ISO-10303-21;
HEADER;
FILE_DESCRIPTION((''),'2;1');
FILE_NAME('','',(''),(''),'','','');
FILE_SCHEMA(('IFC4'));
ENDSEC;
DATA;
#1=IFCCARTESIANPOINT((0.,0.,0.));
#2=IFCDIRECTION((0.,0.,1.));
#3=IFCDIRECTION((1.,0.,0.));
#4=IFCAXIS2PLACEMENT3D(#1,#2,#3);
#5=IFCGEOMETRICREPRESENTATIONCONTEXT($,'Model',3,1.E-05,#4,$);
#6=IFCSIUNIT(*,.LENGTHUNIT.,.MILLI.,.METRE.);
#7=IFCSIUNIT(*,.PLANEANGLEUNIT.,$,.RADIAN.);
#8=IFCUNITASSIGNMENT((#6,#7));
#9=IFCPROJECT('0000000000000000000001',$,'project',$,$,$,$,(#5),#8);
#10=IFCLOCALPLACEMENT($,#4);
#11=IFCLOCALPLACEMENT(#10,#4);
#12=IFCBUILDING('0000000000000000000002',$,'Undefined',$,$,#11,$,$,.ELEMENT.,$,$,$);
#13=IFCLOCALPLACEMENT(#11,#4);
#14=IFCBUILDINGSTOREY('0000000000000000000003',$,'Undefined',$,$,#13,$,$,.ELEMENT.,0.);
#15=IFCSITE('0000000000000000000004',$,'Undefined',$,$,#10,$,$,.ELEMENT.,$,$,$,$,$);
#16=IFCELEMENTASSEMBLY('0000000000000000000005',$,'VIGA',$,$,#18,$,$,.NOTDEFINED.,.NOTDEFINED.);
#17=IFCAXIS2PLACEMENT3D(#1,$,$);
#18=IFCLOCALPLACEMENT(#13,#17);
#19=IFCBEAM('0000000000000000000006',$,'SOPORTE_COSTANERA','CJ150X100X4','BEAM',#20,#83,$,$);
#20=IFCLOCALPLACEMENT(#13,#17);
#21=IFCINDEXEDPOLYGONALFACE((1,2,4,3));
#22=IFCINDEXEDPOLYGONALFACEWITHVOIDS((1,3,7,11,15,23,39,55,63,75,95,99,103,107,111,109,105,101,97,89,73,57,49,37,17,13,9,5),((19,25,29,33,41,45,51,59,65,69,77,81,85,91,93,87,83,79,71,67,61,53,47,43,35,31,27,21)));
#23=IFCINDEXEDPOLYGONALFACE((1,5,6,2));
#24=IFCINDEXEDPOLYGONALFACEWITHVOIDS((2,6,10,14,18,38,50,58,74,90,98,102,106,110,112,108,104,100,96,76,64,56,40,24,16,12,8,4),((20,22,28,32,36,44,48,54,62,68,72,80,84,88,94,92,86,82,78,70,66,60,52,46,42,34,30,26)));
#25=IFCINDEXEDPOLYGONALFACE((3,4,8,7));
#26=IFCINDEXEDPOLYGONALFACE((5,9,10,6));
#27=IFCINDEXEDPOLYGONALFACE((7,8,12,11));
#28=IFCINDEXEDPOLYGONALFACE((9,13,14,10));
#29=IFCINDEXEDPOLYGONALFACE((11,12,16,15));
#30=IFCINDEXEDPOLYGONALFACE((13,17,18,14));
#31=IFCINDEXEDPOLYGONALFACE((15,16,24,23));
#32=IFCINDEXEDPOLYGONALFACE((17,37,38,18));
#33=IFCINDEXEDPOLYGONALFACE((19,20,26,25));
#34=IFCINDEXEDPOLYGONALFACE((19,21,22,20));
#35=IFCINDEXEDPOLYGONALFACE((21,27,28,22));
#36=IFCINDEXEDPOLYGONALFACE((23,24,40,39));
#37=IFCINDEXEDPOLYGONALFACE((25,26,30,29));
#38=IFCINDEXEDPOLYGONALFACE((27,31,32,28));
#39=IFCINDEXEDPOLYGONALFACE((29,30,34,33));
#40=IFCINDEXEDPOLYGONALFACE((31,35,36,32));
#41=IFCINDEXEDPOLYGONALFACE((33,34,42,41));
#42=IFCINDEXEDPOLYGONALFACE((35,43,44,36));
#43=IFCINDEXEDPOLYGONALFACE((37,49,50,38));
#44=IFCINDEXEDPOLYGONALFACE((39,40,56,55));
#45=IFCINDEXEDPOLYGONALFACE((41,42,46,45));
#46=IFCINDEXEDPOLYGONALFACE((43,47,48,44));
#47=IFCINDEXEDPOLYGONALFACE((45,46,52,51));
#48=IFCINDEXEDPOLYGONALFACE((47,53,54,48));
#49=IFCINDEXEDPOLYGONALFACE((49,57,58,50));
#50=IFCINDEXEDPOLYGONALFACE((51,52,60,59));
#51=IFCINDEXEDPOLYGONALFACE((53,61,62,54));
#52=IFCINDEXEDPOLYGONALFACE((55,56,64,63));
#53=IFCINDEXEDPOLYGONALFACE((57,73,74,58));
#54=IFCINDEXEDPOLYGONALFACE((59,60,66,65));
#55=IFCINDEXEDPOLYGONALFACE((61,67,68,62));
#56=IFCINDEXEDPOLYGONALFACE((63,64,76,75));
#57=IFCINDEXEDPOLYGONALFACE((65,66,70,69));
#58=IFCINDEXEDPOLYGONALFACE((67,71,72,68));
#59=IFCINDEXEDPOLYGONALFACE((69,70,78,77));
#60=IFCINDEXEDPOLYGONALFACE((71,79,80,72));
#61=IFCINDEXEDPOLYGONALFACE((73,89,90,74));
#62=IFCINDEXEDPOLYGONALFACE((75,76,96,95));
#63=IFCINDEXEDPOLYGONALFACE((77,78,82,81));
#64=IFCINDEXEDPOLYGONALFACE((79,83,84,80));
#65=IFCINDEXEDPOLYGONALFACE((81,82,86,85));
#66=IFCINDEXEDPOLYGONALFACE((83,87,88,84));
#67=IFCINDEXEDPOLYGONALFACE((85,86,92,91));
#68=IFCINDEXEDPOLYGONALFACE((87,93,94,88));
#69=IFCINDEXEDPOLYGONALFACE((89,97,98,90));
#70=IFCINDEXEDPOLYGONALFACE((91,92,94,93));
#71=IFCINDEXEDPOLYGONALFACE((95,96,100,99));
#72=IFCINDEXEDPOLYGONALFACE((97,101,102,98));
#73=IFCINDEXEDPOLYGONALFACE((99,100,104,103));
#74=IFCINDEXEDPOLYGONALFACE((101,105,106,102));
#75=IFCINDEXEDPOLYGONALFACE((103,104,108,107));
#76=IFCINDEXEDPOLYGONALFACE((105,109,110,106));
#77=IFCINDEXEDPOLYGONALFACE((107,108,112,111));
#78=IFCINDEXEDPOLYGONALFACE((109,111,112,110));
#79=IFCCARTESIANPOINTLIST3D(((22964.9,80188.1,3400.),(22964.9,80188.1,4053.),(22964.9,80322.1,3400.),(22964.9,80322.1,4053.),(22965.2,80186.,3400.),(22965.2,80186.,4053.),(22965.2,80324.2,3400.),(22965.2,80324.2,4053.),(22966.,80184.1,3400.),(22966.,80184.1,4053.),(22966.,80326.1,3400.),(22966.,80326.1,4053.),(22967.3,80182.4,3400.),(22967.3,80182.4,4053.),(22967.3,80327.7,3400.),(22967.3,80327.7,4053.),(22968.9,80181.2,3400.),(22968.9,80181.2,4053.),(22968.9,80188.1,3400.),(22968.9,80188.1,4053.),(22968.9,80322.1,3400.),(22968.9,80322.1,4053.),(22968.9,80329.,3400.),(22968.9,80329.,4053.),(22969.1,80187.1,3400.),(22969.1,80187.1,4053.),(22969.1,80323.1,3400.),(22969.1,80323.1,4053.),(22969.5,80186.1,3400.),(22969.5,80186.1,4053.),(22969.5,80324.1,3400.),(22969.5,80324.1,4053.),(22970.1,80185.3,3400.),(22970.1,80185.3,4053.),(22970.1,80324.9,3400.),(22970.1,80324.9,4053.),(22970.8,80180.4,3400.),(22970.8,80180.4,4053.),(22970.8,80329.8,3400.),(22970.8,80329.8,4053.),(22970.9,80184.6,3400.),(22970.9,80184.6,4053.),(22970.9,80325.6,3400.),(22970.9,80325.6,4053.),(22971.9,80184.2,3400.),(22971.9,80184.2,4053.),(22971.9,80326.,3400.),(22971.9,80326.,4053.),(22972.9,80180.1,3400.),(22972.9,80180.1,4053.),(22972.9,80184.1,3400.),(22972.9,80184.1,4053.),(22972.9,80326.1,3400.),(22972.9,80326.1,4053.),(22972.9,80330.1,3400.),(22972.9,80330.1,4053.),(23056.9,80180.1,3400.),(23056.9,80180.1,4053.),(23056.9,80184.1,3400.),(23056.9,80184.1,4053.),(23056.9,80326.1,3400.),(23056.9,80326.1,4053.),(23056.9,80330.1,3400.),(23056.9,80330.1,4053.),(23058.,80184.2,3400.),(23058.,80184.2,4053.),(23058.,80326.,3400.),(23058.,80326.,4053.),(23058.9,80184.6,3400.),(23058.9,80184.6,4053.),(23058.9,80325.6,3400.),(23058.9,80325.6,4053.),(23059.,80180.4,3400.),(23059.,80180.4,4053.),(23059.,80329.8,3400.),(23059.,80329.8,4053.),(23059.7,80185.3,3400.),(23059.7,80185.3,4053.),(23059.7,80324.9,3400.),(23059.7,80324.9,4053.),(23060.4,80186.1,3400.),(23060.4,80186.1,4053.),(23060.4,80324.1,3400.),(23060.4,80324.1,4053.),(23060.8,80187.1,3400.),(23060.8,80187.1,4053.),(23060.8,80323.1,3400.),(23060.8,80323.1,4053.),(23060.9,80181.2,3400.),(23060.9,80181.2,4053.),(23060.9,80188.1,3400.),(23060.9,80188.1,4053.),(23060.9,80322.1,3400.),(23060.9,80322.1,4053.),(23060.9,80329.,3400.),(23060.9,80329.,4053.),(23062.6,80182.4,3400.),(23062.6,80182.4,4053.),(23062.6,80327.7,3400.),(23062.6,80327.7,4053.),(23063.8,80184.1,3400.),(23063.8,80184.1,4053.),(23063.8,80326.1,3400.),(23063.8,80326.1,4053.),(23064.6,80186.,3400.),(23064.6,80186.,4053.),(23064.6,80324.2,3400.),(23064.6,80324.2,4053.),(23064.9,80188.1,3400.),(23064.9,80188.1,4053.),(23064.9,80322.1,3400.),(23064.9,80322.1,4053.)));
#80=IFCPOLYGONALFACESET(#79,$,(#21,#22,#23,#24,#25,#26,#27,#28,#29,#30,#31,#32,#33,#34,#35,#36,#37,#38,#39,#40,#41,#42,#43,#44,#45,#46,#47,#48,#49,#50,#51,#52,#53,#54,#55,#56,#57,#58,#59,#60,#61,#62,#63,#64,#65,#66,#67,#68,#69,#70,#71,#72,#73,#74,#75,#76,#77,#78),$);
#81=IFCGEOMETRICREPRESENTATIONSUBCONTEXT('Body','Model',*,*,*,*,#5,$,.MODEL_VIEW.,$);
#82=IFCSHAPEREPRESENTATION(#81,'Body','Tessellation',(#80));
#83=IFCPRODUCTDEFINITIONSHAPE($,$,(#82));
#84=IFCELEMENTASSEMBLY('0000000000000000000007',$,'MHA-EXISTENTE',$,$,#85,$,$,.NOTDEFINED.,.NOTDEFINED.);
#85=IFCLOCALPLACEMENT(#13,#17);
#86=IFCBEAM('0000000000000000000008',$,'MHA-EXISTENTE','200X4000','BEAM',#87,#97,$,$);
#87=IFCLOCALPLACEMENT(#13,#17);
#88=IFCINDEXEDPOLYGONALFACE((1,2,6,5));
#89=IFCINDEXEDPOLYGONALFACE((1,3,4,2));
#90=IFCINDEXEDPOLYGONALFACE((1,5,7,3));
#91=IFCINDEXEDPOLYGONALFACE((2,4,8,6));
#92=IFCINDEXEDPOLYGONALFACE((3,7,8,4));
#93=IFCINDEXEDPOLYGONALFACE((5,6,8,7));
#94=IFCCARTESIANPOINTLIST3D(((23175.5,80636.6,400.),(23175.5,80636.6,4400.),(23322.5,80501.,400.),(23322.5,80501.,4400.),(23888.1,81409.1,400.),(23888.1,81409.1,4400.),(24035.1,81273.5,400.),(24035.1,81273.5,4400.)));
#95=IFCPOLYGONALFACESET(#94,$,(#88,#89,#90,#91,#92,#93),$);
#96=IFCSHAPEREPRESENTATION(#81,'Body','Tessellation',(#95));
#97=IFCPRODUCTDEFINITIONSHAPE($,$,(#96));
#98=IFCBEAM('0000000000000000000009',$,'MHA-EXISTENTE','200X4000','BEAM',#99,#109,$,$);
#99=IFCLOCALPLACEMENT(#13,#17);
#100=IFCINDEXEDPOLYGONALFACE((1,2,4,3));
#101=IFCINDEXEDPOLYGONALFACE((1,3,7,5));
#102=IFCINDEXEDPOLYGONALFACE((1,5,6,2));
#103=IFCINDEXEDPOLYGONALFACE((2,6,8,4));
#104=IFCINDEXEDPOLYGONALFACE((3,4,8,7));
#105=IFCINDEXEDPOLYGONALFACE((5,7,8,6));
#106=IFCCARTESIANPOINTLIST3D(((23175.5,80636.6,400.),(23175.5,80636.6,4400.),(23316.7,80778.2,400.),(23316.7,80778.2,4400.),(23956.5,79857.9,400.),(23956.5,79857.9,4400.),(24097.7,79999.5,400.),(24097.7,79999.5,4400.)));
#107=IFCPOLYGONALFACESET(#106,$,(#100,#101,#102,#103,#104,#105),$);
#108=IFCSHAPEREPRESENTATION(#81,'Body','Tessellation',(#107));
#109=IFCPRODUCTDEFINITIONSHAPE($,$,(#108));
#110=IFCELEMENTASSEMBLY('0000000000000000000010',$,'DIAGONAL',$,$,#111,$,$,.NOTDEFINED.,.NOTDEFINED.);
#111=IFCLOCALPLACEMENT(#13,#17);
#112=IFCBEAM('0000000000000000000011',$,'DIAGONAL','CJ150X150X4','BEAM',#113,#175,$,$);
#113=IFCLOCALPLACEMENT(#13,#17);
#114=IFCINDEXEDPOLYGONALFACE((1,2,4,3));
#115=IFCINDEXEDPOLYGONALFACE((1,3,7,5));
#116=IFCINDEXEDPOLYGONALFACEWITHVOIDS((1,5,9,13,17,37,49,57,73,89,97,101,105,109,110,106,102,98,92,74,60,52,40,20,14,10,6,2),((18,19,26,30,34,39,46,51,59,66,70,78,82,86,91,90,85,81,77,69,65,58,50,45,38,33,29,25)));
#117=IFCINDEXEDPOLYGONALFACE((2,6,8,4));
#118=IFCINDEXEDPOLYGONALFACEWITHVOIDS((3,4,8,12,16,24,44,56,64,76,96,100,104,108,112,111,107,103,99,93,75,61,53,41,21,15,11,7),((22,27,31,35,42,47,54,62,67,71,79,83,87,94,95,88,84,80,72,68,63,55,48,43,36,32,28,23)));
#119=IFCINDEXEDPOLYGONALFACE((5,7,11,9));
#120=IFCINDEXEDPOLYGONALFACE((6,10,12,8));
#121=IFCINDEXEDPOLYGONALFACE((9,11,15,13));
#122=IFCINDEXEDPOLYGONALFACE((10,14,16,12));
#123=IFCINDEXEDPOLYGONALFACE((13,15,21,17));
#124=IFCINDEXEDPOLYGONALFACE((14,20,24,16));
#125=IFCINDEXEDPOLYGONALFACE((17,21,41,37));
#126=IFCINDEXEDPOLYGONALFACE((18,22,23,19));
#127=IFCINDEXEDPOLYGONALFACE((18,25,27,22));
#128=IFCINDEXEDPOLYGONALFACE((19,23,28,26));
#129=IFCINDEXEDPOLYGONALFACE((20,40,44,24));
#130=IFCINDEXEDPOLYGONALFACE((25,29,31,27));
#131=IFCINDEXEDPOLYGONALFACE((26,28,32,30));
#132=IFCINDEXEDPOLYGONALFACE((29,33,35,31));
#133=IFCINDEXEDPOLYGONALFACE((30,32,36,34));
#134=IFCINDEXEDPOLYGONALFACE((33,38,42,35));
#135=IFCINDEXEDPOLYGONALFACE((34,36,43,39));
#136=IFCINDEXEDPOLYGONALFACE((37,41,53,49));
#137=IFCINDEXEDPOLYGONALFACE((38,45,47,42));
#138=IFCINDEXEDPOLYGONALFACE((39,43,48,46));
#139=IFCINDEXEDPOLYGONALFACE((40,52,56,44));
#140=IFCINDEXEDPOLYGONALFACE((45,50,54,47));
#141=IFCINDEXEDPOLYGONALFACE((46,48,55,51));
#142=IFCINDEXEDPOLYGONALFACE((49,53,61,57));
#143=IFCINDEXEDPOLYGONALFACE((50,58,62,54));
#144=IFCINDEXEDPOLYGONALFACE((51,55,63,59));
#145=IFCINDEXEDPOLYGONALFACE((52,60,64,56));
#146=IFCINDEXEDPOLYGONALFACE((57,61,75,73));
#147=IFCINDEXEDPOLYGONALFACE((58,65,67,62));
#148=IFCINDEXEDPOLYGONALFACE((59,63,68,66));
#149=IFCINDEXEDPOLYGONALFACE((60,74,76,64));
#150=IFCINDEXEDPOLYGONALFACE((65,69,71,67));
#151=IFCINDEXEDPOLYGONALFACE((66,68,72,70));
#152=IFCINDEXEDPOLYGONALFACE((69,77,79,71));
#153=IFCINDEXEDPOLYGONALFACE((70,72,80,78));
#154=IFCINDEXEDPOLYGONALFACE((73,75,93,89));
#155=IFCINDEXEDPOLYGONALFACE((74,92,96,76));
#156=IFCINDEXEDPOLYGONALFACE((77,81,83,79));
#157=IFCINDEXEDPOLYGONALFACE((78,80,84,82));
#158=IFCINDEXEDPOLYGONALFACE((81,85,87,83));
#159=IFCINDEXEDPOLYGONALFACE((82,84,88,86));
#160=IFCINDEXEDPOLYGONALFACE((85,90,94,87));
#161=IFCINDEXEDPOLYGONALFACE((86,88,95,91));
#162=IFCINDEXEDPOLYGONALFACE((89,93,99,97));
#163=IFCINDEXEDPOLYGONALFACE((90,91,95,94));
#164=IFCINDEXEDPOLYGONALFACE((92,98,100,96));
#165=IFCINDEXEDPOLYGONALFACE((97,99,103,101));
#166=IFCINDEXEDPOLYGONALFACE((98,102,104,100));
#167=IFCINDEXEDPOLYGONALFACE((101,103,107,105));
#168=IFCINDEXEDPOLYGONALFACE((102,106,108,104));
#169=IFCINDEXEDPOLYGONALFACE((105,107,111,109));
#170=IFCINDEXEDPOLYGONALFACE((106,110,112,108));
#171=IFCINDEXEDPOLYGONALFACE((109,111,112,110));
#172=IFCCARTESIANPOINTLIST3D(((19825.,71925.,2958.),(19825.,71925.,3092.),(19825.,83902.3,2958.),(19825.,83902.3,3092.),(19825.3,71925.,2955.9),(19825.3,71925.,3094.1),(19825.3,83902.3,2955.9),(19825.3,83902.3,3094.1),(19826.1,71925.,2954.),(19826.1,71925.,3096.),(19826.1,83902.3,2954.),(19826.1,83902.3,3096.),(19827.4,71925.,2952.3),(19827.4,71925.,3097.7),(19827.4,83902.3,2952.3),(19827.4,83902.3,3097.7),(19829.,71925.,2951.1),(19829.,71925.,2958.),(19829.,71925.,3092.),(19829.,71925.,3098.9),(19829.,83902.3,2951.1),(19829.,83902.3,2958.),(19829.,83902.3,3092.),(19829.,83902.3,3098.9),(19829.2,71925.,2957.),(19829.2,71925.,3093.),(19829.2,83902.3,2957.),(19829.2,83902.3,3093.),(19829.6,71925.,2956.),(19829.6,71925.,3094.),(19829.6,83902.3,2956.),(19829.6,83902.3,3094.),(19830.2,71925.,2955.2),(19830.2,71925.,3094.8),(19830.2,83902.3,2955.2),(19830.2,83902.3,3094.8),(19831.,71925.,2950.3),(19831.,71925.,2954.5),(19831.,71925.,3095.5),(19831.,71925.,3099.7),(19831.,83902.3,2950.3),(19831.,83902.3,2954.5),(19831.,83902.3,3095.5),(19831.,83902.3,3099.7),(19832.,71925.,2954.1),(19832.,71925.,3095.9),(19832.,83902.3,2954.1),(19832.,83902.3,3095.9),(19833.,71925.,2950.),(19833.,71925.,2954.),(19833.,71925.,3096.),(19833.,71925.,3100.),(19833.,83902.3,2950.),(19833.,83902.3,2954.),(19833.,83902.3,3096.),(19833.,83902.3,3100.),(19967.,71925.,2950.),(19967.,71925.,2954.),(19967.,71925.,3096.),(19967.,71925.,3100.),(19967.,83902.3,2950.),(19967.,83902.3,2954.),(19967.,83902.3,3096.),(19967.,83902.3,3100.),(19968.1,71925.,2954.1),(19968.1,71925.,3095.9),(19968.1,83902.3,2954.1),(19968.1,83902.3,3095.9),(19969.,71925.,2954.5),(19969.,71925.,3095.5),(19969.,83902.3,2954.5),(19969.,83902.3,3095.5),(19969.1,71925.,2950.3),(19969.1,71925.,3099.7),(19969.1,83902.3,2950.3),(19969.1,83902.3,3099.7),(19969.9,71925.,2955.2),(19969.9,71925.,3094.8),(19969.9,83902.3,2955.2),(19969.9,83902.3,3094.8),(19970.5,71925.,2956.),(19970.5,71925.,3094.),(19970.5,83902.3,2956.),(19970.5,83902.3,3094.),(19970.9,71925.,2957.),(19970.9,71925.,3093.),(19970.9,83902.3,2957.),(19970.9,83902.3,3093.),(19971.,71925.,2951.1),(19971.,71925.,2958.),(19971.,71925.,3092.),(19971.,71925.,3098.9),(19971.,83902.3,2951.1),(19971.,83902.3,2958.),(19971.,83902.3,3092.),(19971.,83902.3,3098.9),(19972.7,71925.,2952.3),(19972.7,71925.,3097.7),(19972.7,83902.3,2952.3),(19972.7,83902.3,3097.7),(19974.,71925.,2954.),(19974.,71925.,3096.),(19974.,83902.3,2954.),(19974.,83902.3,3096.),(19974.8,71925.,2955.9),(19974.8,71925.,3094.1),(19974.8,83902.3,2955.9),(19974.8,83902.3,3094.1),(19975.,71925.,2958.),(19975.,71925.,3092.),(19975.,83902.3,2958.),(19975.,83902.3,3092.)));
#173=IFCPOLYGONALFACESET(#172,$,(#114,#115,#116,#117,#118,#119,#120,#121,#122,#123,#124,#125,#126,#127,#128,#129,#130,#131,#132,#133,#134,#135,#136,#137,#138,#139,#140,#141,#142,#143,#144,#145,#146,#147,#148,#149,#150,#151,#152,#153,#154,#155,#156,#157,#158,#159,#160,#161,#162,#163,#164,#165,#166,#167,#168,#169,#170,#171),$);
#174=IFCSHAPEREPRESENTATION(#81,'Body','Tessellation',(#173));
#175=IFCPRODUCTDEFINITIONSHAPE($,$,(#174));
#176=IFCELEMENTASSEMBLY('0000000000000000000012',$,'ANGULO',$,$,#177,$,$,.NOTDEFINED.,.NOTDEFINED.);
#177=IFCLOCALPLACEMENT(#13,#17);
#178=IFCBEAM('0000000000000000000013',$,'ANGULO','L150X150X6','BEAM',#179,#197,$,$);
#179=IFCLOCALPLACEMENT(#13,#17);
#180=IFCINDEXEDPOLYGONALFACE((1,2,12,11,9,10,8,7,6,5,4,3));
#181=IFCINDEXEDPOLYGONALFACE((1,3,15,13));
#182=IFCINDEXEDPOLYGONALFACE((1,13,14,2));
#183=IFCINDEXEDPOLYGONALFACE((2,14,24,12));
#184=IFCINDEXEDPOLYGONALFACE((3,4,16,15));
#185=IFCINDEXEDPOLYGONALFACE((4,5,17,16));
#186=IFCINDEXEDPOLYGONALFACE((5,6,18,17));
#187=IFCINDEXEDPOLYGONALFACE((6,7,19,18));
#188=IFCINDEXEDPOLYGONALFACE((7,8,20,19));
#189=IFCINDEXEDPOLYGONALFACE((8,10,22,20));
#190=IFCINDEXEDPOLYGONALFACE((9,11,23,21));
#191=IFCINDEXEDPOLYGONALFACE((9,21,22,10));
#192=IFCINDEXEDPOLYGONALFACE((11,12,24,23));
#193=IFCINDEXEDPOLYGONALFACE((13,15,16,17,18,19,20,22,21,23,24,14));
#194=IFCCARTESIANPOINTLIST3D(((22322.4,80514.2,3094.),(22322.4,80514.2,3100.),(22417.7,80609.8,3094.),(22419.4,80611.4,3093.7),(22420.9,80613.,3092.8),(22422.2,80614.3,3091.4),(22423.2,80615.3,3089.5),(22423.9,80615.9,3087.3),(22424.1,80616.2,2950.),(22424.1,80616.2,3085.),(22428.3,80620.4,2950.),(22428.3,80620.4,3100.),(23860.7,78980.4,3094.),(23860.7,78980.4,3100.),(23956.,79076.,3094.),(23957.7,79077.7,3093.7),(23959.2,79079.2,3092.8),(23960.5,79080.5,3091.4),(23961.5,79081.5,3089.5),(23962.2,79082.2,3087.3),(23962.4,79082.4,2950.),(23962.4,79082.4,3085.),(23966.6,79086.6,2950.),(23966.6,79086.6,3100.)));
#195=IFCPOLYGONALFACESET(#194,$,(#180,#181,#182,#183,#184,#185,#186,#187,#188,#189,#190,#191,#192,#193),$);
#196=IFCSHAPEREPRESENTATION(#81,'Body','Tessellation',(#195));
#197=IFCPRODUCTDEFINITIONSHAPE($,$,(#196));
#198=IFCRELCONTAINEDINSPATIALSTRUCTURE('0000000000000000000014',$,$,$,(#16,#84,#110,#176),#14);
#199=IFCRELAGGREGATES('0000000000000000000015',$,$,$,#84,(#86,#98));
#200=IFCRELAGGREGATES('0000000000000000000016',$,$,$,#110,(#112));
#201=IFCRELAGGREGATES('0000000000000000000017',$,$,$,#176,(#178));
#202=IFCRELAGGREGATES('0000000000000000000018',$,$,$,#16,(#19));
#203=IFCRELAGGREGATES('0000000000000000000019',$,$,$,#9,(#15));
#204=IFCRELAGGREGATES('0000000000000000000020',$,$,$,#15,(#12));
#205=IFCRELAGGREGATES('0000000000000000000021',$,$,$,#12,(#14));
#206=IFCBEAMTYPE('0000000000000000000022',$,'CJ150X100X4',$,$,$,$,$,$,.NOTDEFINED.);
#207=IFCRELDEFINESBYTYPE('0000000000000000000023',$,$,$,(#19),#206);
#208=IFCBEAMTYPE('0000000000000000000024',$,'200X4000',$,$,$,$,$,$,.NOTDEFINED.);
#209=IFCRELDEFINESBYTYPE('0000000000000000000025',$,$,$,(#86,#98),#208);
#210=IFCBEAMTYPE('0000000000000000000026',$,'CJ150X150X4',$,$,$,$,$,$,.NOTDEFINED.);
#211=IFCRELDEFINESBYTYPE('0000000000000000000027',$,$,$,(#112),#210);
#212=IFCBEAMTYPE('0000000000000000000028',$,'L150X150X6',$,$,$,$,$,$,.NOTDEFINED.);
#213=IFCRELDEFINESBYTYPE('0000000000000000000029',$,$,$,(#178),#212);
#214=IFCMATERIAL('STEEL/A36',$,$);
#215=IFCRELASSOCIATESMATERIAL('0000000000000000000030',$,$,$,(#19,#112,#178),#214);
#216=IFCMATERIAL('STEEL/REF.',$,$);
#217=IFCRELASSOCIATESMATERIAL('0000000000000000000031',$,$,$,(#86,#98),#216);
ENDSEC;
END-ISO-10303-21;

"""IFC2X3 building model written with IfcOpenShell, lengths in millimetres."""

from ifc_helpers import new_model, si_unit, frame, origin_with_axes, origin_2d_with_axis, place, context, subcontext, project, spatial, rectangle, hollow_rectangle, l_section, extrude, material, type_object, element, aggregate, save


model = new_model("IFC2X3")

# Units and contexts
model_context = context("Model", 3, precision=1e-05, world=origin_with_axes())
body_context = subcontext(model_context, "Body", "Model", "MODEL_VIEW")
ifc_project = project(units=[si_unit("LENGTHUNIT", "METRE", prefix="MILLI"), si_unit("PLANEANGLEUNIT", "RADIAN")], contexts=[model_context])

# Site, building, storey
site_placement = place(None, origin_with_axes())
site = spatial("IfcSite", under=ifc_project, at=site_placement, Name="Undefined", CompositionType="ELEMENT")
building_placement = place(site_placement, origin_with_axes())
building = spatial("IfcBuilding", under=site, at=building_placement, Name="Undefined", CompositionType="ELEMENT")
storey_placement = place(building_placement, origin_with_axes())
storey = spatial("IfcBuildingStorey", under=building, at=storey_placement, Name="Undefined", CompositionType="ELEMENT", Elevation=0.0)

# Shared definitions
ifc_material_1 = material(Name="STEEL/A36")

# Element assemblies, beams
assembly_1_placement = place(storey_placement, origin_with_axes())
assembly_1 = element("IfcElementAssembly", 1, at=assembly_1_placement, inside=storey, Name="VIGA", AssemblyPlace="NOTDEFINED", PredefinedType="NOTDEFINED")
beam_type_1 = type_object("IfcBeamType", Name="CJ150X100X4", PredefinedType="NOTDEFINED")
beam_1_placement = place(assembly_1_placement, frame((23014.9, 80255.1, 4053.0), z_axis=(0.0, 1.0, 0.0), x_axis=(0.0, 0.0, -1.0)))
beam_1 = element("IfcBeam", 2, at=beam_1_placement, type_object=beam_type_1, material=ifc_material_1, Name="SOPORTE_COSTANERA", Description="CJ150X100X4", ObjectType="BEAM", context=body_context, shape_type="SweptSolid", body=[
    extrude(hollow_rectangle(XDim=100.0, YDim=150.0, WallThickness=4.0, InnerFilletRadius=4.0, OuterFilletRadius=8.0, at=origin_2d_with_axis()), frame((653.0, 0.0, 0.0), z_axis=(-1.0, 0.0, 0.0), x_axis=(0.0, -1.0, 0.0)), (0.0, 0.0, 1.0), 653.0),
])
assembly_2_placement = place(storey_placement, origin_with_axes())
assembly_2 = element("IfcElementAssembly", 3, at=assembly_2_placement, inside=storey, Name="MHA-EXISTENTE", AssemblyPlace="NOTDEFINED", PredefinedType="NOTDEFINED")
ifc_material_2 = material(Name="STEEL/REF.")
beam_type_2 = type_object("IfcBeamType", Name="200X4000", PredefinedType="NOTDEFINED")
beam_2_placement = place(assembly_2_placement, frame((23961.6, 81341.3, 2400.0), z_axis=(0.735006, -0.678061, 0.0), x_axis=(-0.678061, -0.735006, 0.0)))
beam_2 = element("IfcBeam", 4, at=beam_2_placement, type_object=beam_type_2, material=ifc_material_2, Name="MHA-EXISTENTE", Description="200X4000", ObjectType="BEAM", context=body_context, shape_type="SweptSolid", body=[
    extrude(rectangle(XDim=4000.0, YDim=200.0, at=origin_2d_with_axis()), frame((1051.0, 0.0, 0.0), z_axis=(-1.0, 0.0, 0.0), x_axis=(0.0, -1.0, 0.0)), (0.0, 0.0, 1.0), 1051.0),
])
beam_3_placement = place(assembly_2_placement, frame((23246.1, 80707.4, 2400.0), z_axis=(0.706058, 0.708154, 0.0), x_axis=(0.708154, -0.706058, 0.0)))
beam_3 = element("IfcBeam", 5, at=beam_3_placement, type_object=beam_type_2, material=ifc_material_2, Name="MHA-EXISTENTE", Description="200X4000", ObjectType="BEAM", context=body_context, shape_type="SweptSolid", body=[
    extrude(rectangle(XDim=4000.0, YDim=200.0, at=origin_2d_with_axis()), frame((1102.9, 0.0, 0.0), z_axis=(-1.0, 0.0, 0.0), x_axis=(0.0, -1.0, 0.0)), (0.0, 0.0, 1.0), 1102.9),
])
aggregate(assembly_2, [beam_2, beam_3])

# Element assemblies, beams
assembly_3_placement = place(storey_placement, origin_with_axes())
assembly_3 = element("IfcElementAssembly", 6, at=assembly_3_placement, inside=storey, Name="DIAGONAL", AssemblyPlace="NOTDEFINED", PredefinedType="NOTDEFINED")
beam_type_3 = type_object("IfcBeamType", Name="CJ150X150X4", PredefinedType="NOTDEFINED")
beam_4_placement = place(assembly_3_placement, frame((19900.0, 83902.3, 3025.0), z_axis=(0.0, 0.0, 1.0), x_axis=(0.0, -1.0, 0.0)))
beam_4 = element("IfcBeam", 7, at=beam_4_placement, type_object=beam_type_3, material=ifc_material_1, Name="DIAGONAL", Description="CJ150X150X4", ObjectType="BEAM", context=body_context, shape_type="SweptSolid", body=[
    extrude(hollow_rectangle(XDim=150.0, YDim=150.0, WallThickness=4.0, InnerFilletRadius=4.0, OuterFilletRadius=8.0, at=origin_2d_with_axis()), frame((11977.3, 0.0, 0.0), z_axis=(-1.0, 0.0, 0.0), x_axis=(0.0, -1.0, 0.0)), (0.0, 0.0, 1.0), 11977.3),
])
aggregate(assembly_3, [beam_4])
assembly_4_placement = place(storey_placement, origin_with_axes())
assembly_4 = element("IfcElementAssembly", 8, at=assembly_4_placement, inside=storey, Name="ANGULO", AssemblyPlace="NOTDEFINED", PredefinedType="NOTDEFINED")
beam_type_4 = type_object("IfcBeamType", Name="L150X150X6", PredefinedType="NOTDEFINED")
beam_5_placement = place(assembly_4_placement, frame((22375.4, 80567.3, 3025.0), z_axis=(-0.706058, -0.708154, 0.0), x_axis=(0.708154, -0.706058, 0.0)))
beam_5 = element("IfcBeam", 9, at=beam_5_placement, type_object=beam_type_4, material=ifc_material_1, Name="ANGULO", Description="L150X150X6", ObjectType="BEAM", context=body_context, shape_type="SweptSolid", body=[
    extrude(l_section(Depth=150.0, Width=150.0, Thickness=6.0, FilletRadius=9.0, at=origin_2d_with_axis()), frame((2172.3, 0.0, 0.0), z_axis=(-1.0, 0.0, 0.0), x_axis=(0.0, -1.0, 0.0)), (0.0, 0.0, 1.0), 2172.3),
])
aggregate(assembly_4, [beam_5])

aggregate(assembly_1, [beam_1])

save(model, "model.ifc")
